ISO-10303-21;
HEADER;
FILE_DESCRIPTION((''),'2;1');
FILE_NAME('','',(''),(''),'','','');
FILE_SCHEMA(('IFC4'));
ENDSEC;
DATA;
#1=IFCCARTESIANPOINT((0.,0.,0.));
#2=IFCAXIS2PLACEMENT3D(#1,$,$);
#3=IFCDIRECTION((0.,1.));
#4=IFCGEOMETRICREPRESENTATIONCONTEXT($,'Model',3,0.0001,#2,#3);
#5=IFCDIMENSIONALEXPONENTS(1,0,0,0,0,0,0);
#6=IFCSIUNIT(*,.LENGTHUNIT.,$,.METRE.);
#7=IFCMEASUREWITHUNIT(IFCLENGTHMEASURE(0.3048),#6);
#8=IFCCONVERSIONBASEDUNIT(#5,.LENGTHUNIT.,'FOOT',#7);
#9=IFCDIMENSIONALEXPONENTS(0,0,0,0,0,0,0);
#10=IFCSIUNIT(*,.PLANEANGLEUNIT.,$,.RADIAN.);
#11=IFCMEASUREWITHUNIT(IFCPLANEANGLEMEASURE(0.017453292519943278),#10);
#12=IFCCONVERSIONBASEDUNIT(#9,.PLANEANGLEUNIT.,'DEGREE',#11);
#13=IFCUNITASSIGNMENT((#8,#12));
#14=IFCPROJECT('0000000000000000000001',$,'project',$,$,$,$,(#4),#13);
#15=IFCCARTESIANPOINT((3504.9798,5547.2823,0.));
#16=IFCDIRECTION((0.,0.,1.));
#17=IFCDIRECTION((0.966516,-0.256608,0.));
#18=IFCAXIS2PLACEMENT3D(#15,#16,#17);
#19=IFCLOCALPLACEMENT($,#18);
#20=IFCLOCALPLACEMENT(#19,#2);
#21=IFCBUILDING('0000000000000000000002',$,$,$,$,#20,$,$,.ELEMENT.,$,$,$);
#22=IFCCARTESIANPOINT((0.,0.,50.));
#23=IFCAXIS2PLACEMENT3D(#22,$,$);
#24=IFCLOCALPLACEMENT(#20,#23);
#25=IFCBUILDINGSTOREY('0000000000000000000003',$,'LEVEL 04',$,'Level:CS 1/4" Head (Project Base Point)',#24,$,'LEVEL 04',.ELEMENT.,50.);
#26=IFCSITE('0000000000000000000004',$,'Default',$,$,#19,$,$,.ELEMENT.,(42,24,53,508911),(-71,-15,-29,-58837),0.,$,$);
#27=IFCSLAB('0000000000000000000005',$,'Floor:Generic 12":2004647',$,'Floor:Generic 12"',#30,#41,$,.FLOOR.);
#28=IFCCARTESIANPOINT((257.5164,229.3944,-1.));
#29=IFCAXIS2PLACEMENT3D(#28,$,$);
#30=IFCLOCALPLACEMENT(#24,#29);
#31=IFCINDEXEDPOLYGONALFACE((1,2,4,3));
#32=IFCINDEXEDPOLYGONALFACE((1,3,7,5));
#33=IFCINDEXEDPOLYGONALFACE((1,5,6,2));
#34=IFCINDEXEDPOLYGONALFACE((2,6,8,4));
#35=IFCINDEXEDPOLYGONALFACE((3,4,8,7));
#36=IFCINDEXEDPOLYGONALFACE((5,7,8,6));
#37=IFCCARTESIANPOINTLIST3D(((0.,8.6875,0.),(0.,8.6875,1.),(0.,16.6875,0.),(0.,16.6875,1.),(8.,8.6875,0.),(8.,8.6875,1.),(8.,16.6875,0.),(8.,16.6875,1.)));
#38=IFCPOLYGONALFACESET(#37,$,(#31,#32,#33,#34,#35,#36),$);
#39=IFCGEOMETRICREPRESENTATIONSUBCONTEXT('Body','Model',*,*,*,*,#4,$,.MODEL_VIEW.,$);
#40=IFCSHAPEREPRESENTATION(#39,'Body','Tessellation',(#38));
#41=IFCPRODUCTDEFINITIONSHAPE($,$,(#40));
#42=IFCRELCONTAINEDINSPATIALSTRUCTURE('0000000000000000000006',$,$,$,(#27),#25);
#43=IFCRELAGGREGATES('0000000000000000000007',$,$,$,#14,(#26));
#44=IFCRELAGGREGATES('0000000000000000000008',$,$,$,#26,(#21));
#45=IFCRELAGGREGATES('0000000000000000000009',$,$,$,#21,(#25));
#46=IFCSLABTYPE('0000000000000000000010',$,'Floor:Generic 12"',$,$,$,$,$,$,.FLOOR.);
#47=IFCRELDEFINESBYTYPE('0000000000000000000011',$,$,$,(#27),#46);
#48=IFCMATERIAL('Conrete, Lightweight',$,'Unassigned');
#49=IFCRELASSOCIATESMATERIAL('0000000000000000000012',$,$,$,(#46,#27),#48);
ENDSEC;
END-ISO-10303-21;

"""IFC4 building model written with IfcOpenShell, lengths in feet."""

from ifc_helpers import new_model, entity, si_unit, converted_unit, direction, frame, origin, origin_2d_with_axis, place, context, subcontext, project, spatial, rectangle, extrude, material, type_object, element, save


model = new_model("IFC4")

# Units and contexts
model_context = context("Model", 3, precision=0.0001, world=origin(), true_north=direction((0.0, 1.0)))
body_context = subcontext(model_context, "Body", "Model", "MODEL_VIEW")
ifc_project = project(units=[converted_unit("LENGTHUNIT", "FOOT", entity("IfcLengthMeasure", 0.3048), si_unit("LENGTHUNIT", "METRE"), dimensions=[1, 0, 0, 0, 0, 0, 0]), converted_unit("PLANEANGLEUNIT", "DEGREE", entity("IfcPlaneAngleMeasure", 0.017453292519943278), si_unit("PLANEANGLEUNIT", "RADIAN"), dimensions=[0, 0, 0, 0, 0, 0, 0])], contexts=[model_context])

# Site, building, storey
site_placement = place(None, frame((3504.9798, 5547.2823, 0.0), z_axis=(0.0, 0.0, 1.0), x_axis=(0.966516, -0.256608, 0.0)))
site = spatial("IfcSite", under=ifc_project, at=site_placement, Name="Default", CompositionType="ELEMENT", RefLatitude=(42, 24, 53, 508911), RefLongitude=(-71, -15, -29, -58837), RefElevation=0.0)
building_placement = place(site_placement, origin())
building = spatial("IfcBuilding", under=site, at=building_placement, CompositionType="ELEMENT")
storey_placement = place(building_placement, frame((0.0, 0.0, 50.0)))
storey = spatial("IfcBuildingStorey", under=building, at=storey_placement, Name="LEVEL 04", ObjectType="Level:CS 1/4\" Head (Project Base Point)", LongName="LEVEL 04", CompositionType="ELEMENT", Elevation=50.0)

# Slab
ifc_material_1 = material(Name="Conrete, Lightweight", Category="Unassigned")
slab_type = type_object("IfcSlabType", Name="Floor:Generic 12\"", PredefinedType="FLOOR", material=ifc_material_1)
slab_1_placement = place(storey_placement, frame((257.5164, 229.3944, -1.0)))
element("IfcSlab", 1, at=slab_1_placement, inside=storey, type_object=slab_type, material=ifc_material_1, Name="Floor:Generic 12\":2004647", ObjectType="Floor:Generic 12\"", PredefinedType="FLOOR", context=body_context, shape_type="SweptSolid", body=[
    extrude(rectangle(XDim=8.0, YDim=8.0, at=origin_2d_with_axis()), frame((4.0, 12.6875, 1.0), z_axis=(0.0, 0.0, -1.0), x_axis=(-1.0, 0.0, 0.0)), (0.0, 0.0, 1.0), 1.0),
])

save(model, "model.ifc")
